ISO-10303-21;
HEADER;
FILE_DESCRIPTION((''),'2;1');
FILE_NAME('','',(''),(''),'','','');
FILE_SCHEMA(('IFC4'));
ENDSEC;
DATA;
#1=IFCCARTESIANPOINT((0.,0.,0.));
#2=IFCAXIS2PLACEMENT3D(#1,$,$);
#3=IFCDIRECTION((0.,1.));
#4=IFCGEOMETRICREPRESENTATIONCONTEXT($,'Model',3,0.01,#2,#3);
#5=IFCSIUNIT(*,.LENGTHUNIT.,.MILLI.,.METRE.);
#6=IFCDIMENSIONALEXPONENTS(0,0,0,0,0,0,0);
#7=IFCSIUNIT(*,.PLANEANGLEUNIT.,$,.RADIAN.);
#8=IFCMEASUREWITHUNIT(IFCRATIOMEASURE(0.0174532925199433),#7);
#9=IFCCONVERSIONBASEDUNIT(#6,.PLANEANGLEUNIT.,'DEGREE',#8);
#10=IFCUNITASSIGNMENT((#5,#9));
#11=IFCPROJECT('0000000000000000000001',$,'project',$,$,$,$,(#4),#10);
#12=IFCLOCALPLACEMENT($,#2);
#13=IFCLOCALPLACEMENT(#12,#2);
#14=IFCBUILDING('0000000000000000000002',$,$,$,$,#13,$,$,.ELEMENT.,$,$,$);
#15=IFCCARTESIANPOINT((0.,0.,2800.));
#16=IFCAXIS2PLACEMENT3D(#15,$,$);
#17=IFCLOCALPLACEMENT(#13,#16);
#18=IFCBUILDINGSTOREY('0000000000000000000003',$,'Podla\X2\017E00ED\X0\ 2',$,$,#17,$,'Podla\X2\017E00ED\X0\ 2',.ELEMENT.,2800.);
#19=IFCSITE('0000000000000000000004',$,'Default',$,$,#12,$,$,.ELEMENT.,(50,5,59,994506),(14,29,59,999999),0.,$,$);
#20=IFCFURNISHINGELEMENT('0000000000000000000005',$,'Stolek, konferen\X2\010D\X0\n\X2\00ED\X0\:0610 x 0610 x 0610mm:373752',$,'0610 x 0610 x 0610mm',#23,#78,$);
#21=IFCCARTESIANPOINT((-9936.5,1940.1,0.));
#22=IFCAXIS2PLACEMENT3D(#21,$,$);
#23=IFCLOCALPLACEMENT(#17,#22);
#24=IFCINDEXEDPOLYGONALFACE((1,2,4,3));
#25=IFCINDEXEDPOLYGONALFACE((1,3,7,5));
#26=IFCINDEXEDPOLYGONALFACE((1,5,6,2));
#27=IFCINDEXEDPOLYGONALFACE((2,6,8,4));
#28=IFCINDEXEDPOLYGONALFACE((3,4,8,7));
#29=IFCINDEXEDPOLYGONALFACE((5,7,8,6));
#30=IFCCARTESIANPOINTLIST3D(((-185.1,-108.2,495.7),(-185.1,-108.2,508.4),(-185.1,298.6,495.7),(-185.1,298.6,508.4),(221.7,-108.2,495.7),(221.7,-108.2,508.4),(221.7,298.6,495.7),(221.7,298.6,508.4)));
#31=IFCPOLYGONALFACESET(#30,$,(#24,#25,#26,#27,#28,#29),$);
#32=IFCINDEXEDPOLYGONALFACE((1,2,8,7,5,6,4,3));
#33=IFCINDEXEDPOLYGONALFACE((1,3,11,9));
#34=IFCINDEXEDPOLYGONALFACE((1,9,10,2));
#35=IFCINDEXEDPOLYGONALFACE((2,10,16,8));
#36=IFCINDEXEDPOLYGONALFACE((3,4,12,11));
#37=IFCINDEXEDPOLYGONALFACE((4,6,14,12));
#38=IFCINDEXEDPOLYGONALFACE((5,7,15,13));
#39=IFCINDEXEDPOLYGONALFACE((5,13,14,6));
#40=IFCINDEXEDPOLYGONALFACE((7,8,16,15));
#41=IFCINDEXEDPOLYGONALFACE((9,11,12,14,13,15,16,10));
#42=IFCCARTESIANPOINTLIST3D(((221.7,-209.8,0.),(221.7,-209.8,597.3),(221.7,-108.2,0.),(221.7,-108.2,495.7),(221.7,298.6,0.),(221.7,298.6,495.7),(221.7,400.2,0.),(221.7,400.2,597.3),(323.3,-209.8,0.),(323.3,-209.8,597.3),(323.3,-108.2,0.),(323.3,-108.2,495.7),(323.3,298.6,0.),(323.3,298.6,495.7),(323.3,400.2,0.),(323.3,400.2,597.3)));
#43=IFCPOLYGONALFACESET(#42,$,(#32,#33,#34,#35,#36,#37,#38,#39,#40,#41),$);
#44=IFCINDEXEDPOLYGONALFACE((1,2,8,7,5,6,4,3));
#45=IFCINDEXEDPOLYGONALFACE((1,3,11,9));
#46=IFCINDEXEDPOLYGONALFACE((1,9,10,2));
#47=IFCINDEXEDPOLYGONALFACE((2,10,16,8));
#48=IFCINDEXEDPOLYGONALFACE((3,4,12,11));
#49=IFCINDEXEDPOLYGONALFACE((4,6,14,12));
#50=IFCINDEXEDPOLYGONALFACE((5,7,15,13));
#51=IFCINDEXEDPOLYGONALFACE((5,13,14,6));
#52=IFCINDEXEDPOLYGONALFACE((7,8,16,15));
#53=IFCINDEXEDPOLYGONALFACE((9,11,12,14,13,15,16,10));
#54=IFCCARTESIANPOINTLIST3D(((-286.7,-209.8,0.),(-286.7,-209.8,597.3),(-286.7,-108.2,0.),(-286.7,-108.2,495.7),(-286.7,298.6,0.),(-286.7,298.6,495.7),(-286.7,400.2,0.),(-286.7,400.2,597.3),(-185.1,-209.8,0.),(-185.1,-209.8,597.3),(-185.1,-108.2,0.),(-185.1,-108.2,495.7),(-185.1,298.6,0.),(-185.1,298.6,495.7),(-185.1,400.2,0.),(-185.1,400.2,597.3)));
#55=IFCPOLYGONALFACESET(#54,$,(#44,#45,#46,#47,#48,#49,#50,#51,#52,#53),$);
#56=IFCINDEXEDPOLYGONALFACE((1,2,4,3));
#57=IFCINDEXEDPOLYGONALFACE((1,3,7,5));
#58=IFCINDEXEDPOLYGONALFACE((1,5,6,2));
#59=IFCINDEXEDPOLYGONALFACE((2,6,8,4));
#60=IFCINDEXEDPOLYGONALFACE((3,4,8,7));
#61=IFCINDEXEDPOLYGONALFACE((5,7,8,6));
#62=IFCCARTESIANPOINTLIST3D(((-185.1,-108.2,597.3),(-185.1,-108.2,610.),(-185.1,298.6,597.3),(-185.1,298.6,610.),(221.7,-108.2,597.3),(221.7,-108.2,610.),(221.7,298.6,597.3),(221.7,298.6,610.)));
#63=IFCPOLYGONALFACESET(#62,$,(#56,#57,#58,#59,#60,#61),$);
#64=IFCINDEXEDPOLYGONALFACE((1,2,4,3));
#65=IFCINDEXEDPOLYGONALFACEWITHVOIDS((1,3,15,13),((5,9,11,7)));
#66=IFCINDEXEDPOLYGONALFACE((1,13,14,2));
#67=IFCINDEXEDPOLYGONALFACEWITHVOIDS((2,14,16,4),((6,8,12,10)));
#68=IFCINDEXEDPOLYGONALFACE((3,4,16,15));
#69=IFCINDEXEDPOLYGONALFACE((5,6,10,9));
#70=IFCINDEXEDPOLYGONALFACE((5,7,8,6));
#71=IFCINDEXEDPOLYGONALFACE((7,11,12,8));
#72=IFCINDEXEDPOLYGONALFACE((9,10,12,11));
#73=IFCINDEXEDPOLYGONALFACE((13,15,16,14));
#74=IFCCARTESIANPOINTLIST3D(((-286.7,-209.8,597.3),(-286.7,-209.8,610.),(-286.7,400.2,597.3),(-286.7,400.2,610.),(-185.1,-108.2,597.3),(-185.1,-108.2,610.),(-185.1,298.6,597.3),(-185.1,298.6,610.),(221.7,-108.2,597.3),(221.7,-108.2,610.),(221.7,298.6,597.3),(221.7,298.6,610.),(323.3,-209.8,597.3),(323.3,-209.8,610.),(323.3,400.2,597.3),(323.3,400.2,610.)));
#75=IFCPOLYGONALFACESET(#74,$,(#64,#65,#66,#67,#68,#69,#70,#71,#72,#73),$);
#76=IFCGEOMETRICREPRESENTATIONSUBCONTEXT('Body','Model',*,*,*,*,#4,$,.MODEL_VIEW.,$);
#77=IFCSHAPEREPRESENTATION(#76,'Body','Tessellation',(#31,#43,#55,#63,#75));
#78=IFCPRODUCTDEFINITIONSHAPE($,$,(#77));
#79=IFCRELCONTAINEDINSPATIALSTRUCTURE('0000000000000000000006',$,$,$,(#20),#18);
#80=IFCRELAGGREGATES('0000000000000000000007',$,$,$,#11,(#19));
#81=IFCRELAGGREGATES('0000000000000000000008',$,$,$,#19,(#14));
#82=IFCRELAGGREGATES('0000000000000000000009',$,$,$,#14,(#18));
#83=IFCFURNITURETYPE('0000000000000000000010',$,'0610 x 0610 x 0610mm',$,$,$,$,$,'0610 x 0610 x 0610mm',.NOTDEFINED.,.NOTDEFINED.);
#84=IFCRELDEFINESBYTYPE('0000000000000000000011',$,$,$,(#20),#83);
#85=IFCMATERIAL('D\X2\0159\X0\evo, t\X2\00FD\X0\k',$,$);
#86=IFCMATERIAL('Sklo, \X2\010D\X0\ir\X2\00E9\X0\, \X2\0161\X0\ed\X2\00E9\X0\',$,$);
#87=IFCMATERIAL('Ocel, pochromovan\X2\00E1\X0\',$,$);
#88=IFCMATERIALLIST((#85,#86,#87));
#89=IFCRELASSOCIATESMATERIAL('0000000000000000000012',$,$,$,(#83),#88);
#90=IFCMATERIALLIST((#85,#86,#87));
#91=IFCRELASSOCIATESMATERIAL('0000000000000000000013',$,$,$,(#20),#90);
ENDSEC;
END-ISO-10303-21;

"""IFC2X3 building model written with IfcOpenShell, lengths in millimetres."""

from ifc_helpers import new_model, entity, si_unit, converted_unit, direction, frame, origin, origin_2d_with_axis, place, context, subcontext, project, spatial, polyline, rectangle, outline, extrude, source, transform, mapped, material, material_list, type_object, type_shapes, element, save


model = new_model("IFC2X3")

# Units and contexts
model_context = context("Model", 3, precision=0.01, world=origin(), true_north=direction((0.0, 1.0)))
body_context = subcontext(model_context, "Body", "Model", "MODEL_VIEW")
ifc_project = project(units=[si_unit("LENGTHUNIT", "METRE", prefix="MILLI"), converted_unit("PLANEANGLEUNIT", "DEGREE", entity("IfcRatioMeasure", 0.0174532925199433), si_unit("PLANEANGLEUNIT", "RADIAN"), dimensions=[0, 0, 0, 0, 0, 0, 0])], contexts=[model_context])

# Site, building, storey
site_placement = place(None, origin())
site = spatial("IfcSite", under=ifc_project, at=site_placement, Name="Default", CompositionType="ELEMENT", RefLatitude=(50, 5, 59, 994506), RefLongitude=(14, 29, 59, 999999), RefElevation=0.0)
building_placement = place(site_placement, origin())
building = spatial("IfcBuilding", under=site, at=building_placement, CompositionType="ELEMENT")
storey_placement = place(building_placement, frame((0.0, 0.0, 2800.0)))
storey = spatial("IfcBuildingStorey", under=building, at=storey_placement, Name="Podlaží 2", LongName="Podlaží 2", CompositionType="ELEMENT", Elevation=2800.0)

# Furnishing element
ifc_material_1 = material(Name="Dřevo, týk")
ifc_material_2 = material(Name="Sklo, čiré, šedé")
ifc_material_3 = material(Name="Ocel, pochromovaná")
ifc_material_list_1 = material_list([ifc_material_1, ifc_material_2, ifc_material_3])
ifc_material_list_2 = material_list([ifc_material_1, ifc_material_2, ifc_material_3])
furniture_type = type_object("IfcFurnitureType", Name="0610 x 0610 x 0610mm", ElementType="0610 x 0610 x 0610mm", AssemblyPlace="NOTDEFINED", material=ifc_material_list_2)
shared_shape_1 = source(origin(), body_context, "Body", "SweptSolid", [
    extrude(rectangle(XDim=406.8, YDim=406.8, at=origin_2d_with_axis()), frame((18.3, 95.2, 495.7), z_axis=(0.0, 0.0, 1.0), x_axis=(-1.0, 0.0, 0.0)), (0.0, 0.0, 1.0), 12.7),
    extrude(outline(polyline([(-273.2, -305.0), (324.0, -305.0), (324.0, 305.0), (-273.2, 305.0), (-273.2, 203.4), (222.5, 203.4), (222.5, -203.4), (-273.2, -203.4), (-273.2, -305.0)])), frame((221.7, 95.2, 273.2), z_axis=(1.0, 0.0, 0.0), x_axis=(0.0, 0.0, 1.0)), (0.0, 0.0, 1.0), 101.6),
    extrude(outline(polyline([(-305.0, -324.1), (305.0, -324.1), (305.0, 273.3), (203.4, 273.3), (203.4, -222.4), (-203.4, -222.4), (-203.4, 273.3), (-305.0, 273.3), (-305.0, -324.1)])), frame((-286.7, 95.2, 273.3), z_axis=(1.0, 0.0, 0.0), x_axis=(0.0, -1.0, 0.0)), (0.0, 0.0, 1.0), 101.6),
    extrude(rectangle(XDim=406.8, YDim=406.8, at=origin_2d_with_axis()), frame((18.3, 95.2, 597.3), z_axis=(0.0, 0.0, 1.0), x_axis=(-1.0, 0.0, 0.0)), (0.0, 0.0, 1.0), 12.7),
    extrude(outline(polyline([(-305.0, -305.0), (305.0, -305.0), (305.0, 305.0), (-305.0, 305.0), (-305.0, -305.0)]), holes=[polyline([(-203.4, -203.4), (-203.4, 203.4), (203.4, 203.4), (203.4, -203.4), (-203.4, -203.4)])]), frame((18.3, 95.2, 597.3), z_axis=(0.0, 0.0, 1.0), x_axis=(-1.0, 0.0, 0.0)), (0.0, 0.0, 1.0), 12.7),
])
type_shapes(furniture_type, [shared_shape_1])
furnishing_placement = place(storey_placement, frame((-9936.5, 1940.1, 0.0)))
element("IfcFurnishingElement", 1, at=furnishing_placement, inside=storey, type_object=furniture_type, material=ifc_material_list_1, Name="Stolek, konferenční:0610 x 0610 x 0610mm:373752", ObjectType="0610 x 0610 x 0610mm", context=body_context, shape_type="MappedRepresentation", body=[
    mapped(shared_shape_1, transform((0.0, 0.0, 0.0), scale=1.0)),
])

save(model, "model.ifc")
